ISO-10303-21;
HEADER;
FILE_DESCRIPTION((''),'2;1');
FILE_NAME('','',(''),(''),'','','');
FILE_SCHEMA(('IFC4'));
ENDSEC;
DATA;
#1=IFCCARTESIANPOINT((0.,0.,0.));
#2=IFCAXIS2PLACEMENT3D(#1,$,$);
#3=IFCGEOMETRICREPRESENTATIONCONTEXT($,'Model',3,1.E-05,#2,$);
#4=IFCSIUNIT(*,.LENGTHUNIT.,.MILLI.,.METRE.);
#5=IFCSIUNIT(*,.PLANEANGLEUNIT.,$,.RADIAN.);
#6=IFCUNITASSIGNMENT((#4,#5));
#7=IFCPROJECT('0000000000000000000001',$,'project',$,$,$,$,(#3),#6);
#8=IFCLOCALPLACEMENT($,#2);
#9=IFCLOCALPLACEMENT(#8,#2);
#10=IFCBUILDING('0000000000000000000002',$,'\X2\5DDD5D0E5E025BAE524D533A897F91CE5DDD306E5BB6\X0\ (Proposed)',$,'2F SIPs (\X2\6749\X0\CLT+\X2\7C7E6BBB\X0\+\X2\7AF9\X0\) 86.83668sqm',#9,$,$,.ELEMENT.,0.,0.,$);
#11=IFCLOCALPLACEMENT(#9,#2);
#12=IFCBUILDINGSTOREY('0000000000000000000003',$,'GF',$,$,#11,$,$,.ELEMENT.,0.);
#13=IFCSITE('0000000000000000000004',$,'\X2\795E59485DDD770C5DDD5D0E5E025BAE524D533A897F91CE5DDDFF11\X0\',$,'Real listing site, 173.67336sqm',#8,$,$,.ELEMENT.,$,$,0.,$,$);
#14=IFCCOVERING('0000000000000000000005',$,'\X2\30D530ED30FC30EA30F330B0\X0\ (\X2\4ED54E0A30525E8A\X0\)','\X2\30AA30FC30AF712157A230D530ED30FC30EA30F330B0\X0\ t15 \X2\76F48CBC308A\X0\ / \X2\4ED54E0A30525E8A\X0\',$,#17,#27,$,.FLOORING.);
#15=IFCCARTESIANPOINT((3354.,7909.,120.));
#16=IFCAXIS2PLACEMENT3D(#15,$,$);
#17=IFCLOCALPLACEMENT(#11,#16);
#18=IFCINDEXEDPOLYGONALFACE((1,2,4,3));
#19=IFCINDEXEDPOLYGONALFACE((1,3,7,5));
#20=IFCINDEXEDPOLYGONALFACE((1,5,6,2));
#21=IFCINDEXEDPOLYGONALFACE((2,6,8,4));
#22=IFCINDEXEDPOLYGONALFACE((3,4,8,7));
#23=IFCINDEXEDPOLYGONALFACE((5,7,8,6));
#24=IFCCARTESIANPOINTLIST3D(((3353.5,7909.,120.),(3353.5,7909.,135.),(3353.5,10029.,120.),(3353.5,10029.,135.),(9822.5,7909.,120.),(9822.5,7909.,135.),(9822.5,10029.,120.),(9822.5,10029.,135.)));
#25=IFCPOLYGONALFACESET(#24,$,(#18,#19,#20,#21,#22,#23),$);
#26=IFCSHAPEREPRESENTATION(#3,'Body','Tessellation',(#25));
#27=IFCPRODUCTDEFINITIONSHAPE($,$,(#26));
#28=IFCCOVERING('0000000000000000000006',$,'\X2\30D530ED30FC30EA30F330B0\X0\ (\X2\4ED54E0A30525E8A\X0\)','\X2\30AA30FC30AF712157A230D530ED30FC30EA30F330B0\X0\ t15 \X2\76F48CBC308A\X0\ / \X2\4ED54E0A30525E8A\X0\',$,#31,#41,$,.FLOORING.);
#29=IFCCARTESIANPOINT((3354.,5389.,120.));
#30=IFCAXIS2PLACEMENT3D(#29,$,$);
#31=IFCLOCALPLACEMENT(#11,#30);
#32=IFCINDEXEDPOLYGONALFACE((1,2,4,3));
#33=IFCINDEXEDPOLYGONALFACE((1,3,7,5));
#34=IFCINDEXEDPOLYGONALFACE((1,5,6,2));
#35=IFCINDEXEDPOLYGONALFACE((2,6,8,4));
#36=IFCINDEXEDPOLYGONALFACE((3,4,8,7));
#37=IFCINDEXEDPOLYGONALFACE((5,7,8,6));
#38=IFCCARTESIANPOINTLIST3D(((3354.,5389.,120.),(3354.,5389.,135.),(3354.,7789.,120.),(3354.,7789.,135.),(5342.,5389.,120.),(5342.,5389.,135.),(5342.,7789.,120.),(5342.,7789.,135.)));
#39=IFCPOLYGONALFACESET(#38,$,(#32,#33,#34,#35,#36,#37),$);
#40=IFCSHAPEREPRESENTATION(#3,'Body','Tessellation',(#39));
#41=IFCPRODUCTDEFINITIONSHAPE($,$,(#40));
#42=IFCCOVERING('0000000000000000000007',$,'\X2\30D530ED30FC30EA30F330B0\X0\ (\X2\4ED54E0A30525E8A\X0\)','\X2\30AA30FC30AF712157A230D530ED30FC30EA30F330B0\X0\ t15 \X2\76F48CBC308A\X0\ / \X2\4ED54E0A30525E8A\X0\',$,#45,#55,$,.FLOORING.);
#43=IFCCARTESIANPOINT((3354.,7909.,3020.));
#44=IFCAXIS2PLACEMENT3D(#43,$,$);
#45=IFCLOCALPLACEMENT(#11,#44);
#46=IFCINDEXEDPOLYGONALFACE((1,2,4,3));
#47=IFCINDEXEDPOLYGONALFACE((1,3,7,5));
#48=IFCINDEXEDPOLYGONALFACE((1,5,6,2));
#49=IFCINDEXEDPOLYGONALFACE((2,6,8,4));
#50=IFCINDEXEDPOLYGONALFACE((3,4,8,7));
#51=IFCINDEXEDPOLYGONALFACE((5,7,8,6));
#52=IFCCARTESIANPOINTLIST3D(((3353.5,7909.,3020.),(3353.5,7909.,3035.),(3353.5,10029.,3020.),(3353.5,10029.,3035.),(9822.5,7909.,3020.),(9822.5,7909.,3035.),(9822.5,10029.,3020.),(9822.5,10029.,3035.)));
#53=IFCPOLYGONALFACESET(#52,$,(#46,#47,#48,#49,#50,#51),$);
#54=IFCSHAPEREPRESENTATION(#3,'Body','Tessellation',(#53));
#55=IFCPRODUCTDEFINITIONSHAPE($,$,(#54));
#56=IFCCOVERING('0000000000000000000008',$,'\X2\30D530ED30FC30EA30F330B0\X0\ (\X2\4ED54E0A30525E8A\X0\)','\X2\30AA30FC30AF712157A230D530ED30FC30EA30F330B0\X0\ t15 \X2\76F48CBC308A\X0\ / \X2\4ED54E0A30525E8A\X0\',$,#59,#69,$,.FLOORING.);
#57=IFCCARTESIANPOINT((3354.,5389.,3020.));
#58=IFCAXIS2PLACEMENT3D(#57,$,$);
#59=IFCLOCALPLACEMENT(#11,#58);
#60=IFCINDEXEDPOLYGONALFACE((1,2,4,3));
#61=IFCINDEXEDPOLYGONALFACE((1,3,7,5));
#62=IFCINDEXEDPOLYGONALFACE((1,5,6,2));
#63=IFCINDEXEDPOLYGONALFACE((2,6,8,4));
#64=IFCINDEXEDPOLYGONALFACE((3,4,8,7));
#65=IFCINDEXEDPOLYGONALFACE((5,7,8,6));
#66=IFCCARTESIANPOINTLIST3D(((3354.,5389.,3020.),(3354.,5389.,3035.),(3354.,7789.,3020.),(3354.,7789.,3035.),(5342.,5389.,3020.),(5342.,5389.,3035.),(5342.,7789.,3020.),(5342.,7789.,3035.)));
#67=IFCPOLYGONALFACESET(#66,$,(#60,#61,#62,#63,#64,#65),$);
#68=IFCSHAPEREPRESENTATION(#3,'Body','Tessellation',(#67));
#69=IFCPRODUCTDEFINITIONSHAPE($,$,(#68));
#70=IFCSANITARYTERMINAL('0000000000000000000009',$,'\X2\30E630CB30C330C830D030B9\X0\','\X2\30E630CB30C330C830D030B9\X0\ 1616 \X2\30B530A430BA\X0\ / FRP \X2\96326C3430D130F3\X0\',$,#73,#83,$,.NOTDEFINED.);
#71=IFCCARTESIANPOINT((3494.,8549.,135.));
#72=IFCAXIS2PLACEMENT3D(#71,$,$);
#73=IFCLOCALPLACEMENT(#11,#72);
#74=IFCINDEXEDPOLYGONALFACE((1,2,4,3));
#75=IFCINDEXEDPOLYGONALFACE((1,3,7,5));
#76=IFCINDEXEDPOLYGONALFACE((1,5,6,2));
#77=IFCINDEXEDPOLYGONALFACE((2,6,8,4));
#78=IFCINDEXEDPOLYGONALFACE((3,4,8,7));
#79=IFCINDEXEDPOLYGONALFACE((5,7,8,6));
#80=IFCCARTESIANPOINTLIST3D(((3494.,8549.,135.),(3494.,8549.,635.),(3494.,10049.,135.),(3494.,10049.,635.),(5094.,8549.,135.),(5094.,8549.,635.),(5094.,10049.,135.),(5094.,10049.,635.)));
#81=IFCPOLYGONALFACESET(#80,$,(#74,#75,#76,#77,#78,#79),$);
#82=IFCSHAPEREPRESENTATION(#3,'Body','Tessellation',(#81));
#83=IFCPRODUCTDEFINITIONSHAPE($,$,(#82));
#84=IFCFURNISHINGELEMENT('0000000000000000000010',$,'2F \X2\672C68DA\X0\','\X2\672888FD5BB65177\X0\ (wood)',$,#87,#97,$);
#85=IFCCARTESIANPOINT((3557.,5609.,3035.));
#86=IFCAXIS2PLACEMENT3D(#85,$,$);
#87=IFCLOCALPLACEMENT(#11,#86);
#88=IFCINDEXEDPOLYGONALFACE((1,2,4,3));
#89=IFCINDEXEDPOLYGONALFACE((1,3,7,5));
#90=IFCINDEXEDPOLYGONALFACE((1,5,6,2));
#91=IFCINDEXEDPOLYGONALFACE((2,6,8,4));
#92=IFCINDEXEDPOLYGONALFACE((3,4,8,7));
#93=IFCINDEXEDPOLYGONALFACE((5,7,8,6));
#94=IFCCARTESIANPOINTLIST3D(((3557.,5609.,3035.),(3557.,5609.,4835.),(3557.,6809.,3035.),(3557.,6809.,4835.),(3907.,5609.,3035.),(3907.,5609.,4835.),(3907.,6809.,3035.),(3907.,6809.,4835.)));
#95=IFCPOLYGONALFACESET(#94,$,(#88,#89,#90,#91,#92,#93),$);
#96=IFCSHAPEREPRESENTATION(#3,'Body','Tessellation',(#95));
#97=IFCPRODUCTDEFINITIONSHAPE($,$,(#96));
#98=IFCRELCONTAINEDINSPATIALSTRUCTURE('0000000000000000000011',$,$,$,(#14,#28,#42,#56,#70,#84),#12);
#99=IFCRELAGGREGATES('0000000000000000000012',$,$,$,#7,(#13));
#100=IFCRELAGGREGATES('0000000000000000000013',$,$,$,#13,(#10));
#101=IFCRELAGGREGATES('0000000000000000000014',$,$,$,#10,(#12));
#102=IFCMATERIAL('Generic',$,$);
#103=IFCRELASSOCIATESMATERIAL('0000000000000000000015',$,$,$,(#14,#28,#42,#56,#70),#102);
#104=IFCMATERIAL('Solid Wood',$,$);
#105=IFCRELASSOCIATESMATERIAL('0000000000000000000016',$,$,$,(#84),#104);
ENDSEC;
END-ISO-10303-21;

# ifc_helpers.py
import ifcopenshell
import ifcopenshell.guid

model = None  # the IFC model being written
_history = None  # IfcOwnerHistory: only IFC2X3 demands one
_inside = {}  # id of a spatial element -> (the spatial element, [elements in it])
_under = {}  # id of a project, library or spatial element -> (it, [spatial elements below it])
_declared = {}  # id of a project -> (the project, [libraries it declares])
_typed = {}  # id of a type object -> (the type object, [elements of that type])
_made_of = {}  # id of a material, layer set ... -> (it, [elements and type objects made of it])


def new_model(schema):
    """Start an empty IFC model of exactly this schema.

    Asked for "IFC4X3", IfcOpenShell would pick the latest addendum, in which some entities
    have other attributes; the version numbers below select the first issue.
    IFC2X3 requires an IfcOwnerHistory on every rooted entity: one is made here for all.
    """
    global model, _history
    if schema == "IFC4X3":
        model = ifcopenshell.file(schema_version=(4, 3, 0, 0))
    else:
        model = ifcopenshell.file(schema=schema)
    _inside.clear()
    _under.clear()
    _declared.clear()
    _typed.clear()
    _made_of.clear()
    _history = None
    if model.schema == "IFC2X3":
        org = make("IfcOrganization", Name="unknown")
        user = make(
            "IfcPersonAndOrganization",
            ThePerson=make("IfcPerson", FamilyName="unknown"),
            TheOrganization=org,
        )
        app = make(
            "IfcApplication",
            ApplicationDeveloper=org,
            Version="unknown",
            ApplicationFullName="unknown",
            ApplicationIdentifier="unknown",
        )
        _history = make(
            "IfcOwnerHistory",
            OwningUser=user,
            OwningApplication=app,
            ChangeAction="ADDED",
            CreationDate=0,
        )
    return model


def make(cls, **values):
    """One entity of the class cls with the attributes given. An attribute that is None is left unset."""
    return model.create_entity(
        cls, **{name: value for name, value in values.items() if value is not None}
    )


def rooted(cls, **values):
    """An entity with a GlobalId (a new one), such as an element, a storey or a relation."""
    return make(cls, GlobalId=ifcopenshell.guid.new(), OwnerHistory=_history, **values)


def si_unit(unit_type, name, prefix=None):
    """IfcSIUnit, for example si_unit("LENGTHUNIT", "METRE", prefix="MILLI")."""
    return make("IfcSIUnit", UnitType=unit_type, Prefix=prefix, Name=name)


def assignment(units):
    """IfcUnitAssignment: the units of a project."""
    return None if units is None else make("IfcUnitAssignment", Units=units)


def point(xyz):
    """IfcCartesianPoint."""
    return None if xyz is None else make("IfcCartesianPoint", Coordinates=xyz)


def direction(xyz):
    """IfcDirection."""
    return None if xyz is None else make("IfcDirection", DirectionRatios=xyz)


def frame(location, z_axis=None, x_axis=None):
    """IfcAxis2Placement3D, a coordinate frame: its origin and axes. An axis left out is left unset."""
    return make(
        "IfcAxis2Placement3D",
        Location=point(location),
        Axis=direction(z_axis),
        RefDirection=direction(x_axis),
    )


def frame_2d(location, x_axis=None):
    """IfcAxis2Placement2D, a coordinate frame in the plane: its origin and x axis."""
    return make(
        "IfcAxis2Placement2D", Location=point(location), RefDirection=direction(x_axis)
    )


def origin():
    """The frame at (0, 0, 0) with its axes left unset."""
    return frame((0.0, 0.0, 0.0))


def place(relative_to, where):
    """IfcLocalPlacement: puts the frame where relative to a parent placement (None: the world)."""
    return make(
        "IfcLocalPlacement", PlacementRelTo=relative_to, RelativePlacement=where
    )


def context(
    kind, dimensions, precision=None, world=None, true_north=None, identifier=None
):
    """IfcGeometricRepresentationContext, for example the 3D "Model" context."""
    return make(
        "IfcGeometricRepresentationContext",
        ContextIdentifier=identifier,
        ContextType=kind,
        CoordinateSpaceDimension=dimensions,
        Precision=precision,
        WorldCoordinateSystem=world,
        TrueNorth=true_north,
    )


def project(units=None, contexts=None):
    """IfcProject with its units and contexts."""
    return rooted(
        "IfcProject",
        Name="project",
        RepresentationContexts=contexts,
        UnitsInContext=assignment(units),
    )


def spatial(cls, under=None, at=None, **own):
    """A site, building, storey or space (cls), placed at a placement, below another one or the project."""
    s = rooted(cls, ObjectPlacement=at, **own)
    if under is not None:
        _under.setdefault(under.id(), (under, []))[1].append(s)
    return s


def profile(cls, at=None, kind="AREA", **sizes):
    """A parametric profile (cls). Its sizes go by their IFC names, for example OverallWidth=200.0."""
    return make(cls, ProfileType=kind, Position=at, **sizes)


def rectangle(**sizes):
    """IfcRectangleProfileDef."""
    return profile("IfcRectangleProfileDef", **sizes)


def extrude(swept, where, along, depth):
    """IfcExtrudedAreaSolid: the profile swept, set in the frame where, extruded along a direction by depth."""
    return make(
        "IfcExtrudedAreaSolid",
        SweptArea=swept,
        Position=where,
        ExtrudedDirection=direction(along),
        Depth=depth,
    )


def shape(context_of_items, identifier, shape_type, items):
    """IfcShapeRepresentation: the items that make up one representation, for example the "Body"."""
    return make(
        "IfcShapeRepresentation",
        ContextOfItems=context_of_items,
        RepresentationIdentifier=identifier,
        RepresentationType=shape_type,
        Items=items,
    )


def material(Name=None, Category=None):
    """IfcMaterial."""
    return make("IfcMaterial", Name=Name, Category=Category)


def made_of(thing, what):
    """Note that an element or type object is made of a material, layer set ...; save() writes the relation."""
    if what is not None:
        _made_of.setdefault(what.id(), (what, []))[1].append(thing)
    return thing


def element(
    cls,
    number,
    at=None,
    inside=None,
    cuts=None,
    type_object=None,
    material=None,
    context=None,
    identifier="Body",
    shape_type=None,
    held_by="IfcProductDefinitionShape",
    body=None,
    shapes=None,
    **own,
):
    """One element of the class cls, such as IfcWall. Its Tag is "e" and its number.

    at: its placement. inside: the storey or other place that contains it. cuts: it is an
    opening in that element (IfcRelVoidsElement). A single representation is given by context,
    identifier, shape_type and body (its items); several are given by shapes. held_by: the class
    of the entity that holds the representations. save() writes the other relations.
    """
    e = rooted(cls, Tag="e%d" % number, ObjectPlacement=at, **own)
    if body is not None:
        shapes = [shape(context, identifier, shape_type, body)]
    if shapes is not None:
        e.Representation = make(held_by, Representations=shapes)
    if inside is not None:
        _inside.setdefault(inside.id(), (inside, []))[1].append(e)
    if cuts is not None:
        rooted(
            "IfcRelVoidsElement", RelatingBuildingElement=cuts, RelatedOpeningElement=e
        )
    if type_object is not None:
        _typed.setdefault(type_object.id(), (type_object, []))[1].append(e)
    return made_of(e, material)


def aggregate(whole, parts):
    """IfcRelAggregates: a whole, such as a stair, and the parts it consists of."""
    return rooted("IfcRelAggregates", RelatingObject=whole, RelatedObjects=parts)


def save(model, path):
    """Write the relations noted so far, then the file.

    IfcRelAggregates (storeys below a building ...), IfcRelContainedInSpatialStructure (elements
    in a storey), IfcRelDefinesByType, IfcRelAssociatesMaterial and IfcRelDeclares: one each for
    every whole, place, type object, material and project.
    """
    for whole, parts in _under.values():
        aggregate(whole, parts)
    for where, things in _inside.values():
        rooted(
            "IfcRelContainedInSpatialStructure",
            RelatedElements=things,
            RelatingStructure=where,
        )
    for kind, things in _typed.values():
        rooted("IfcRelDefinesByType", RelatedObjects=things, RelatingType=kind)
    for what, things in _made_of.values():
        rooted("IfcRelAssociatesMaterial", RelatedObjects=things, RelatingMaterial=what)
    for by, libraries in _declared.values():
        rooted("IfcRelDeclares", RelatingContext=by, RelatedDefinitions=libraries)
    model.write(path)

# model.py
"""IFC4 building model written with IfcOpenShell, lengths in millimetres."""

from ifc_helpers import new_model, si_unit, frame, frame_2d, origin, place, context, project, spatial, rectangle, extrude, material, element, save


model = new_model("IFC4")

# Units and contexts
model_context = context("Model", 3, precision=1e-05, world=origin())
ifc_project = project(units=[si_unit("LENGTHUNIT", "METRE", prefix="MILLI"), si_unit("PLANEANGLEUNIT", "RADIAN")], contexts=[model_context])

# Site, building, storey
site_placement = place(None, origin())
site = spatial("IfcSite", under=ifc_project, at=site_placement, Name="神奈川県川崎市宮前区西野川１", ObjectType="Real listing site, 173.67336sqm", CompositionType="ELEMENT", RefElevation=0.0)
building_placement = place(site_placement, origin())
building = spatial("IfcBuilding", under=site, at=building_placement, Name="川崎市宮前区西野川の家 (Proposed)", ObjectType="2F SIPs (杉CLT+籾殻+竹) 86.83668sqm", CompositionType="ELEMENT", ElevationOfRefHeight=0.0, ElevationOfTerrain=0.0)
storey_placement = place(building_placement, origin())
storey = spatial("IfcBuildingStorey", under=building, at=storey_placement, Name="GF", CompositionType="ELEMENT", Elevation=0.0)

# Shared definitions
ifc_material_1 = material(Name="Solid Wood")

# Coverings
ifc_material_2 = material(Name="Generic")
covering_1_placement = place(storey_placement, frame((3354.0, 7909.0, 120.0)))
element("IfcCovering", 1, at=covering_1_placement, inside=storey, material=ifc_material_2, Name="フローリング (仕上げ床)", Description="オーク無垢フローリング t15 直貼り / 仕上げ床", PredefinedType="FLOORING", context=model_context, shape_type="SweptSolid", body=[
    extrude(rectangle(XDim=6469.0, YDim=2120.0, at=frame_2d((3234.0, 1060.0))), frame((3354.0, 7909.0, 120.0)), (0.0, 0.0, 1.0), 15.0),
])
covering_2_placement = place(storey_placement, frame((3354.0, 5389.0, 120.0)))
element("IfcCovering", 2, at=covering_2_placement, inside=storey, material=ifc_material_2, Name="フローリング (仕上げ床)", Description="オーク無垢フローリング t15 直貼り / 仕上げ床", PredefinedType="FLOORING", context=model_context, shape_type="SweptSolid", body=[
    extrude(rectangle(XDim=1988.0, YDim=2400.0, at=frame_2d((994.0, 1200.0))), frame((3354.0, 5389.0, 120.0)), (0.0, 0.0, 1.0), 15.0),
])
covering_3_placement = place(storey_placement, frame((3354.0, 7909.0, 3020.0)))
element("IfcCovering", 3, at=covering_3_placement, inside=storey, material=ifc_material_2, Name="フローリング (仕上げ床)", Description="オーク無垢フローリング t15 直貼り / 仕上げ床", PredefinedType="FLOORING", context=model_context, shape_type="SweptSolid", body=[
    extrude(rectangle(XDim=6469.0, YDim=2120.0, at=frame_2d((3234.0, 1060.0))), frame((3354.0, 7909.0, 3020.0)), (0.0, 0.0, 1.0), 15.0),
])
covering_4_placement = place(storey_placement, frame((3354.0, 5389.0, 3020.0)))
element("IfcCovering", 4, at=covering_4_placement, inside=storey, material=ifc_material_2, Name="フローリング (仕上げ床)", Description="オーク無垢フローリング t15 直貼り / 仕上げ床", PredefinedType="FLOORING", context=model_context, shape_type="SweptSolid", body=[
    extrude(rectangle(XDim=1988.0, YDim=2400.0, at=frame_2d((994.0, 1200.0))), frame((3354.0, 5389.0, 3020.0)), (0.0, 0.0, 1.0), 15.0),
])

# Sanitary terminal
sanitary_terminal_placement = place(storey_placement, frame((3494.0, 8549.0, 135.0)))
element("IfcSanitaryTerminal", 5, at=sanitary_terminal_placement, inside=storey, material=ifc_material_2, Name="ユニットバス", Description="ユニットバス 1616 サイズ / FRP 防水パン", PredefinedType="NOTDEFINED", context=model_context, shape_type="SweptSolid", body=[
    extrude(rectangle(XDim=1600.0, YDim=1500.0, at=frame_2d((800.0, 750.0))), frame((3494.0, 8549.0, 135.0)), (0.0, 0.0, 1.0), 500.0),
])

# Furnishing element
furnishing_placement = place(storey_placement, frame((3557.0, 5609.0, 3035.0)))
element("IfcFurnishingElement", 6, at=furnishing_placement, inside=storey, material=ifc_material_1, Name="2F 本棚", Description="木製家具 (wood)", context=model_context, shape_type="SweptSolid", body=[
    extrude(rectangle(XDim=350.0, YDim=1200.0, at=frame_2d((175.0, 600.0))), frame((3557.0, 5609.0, 3035.0)), (0.0, 0.0, 1.0), 1800.0),
])

save(model, "model.ifc")
